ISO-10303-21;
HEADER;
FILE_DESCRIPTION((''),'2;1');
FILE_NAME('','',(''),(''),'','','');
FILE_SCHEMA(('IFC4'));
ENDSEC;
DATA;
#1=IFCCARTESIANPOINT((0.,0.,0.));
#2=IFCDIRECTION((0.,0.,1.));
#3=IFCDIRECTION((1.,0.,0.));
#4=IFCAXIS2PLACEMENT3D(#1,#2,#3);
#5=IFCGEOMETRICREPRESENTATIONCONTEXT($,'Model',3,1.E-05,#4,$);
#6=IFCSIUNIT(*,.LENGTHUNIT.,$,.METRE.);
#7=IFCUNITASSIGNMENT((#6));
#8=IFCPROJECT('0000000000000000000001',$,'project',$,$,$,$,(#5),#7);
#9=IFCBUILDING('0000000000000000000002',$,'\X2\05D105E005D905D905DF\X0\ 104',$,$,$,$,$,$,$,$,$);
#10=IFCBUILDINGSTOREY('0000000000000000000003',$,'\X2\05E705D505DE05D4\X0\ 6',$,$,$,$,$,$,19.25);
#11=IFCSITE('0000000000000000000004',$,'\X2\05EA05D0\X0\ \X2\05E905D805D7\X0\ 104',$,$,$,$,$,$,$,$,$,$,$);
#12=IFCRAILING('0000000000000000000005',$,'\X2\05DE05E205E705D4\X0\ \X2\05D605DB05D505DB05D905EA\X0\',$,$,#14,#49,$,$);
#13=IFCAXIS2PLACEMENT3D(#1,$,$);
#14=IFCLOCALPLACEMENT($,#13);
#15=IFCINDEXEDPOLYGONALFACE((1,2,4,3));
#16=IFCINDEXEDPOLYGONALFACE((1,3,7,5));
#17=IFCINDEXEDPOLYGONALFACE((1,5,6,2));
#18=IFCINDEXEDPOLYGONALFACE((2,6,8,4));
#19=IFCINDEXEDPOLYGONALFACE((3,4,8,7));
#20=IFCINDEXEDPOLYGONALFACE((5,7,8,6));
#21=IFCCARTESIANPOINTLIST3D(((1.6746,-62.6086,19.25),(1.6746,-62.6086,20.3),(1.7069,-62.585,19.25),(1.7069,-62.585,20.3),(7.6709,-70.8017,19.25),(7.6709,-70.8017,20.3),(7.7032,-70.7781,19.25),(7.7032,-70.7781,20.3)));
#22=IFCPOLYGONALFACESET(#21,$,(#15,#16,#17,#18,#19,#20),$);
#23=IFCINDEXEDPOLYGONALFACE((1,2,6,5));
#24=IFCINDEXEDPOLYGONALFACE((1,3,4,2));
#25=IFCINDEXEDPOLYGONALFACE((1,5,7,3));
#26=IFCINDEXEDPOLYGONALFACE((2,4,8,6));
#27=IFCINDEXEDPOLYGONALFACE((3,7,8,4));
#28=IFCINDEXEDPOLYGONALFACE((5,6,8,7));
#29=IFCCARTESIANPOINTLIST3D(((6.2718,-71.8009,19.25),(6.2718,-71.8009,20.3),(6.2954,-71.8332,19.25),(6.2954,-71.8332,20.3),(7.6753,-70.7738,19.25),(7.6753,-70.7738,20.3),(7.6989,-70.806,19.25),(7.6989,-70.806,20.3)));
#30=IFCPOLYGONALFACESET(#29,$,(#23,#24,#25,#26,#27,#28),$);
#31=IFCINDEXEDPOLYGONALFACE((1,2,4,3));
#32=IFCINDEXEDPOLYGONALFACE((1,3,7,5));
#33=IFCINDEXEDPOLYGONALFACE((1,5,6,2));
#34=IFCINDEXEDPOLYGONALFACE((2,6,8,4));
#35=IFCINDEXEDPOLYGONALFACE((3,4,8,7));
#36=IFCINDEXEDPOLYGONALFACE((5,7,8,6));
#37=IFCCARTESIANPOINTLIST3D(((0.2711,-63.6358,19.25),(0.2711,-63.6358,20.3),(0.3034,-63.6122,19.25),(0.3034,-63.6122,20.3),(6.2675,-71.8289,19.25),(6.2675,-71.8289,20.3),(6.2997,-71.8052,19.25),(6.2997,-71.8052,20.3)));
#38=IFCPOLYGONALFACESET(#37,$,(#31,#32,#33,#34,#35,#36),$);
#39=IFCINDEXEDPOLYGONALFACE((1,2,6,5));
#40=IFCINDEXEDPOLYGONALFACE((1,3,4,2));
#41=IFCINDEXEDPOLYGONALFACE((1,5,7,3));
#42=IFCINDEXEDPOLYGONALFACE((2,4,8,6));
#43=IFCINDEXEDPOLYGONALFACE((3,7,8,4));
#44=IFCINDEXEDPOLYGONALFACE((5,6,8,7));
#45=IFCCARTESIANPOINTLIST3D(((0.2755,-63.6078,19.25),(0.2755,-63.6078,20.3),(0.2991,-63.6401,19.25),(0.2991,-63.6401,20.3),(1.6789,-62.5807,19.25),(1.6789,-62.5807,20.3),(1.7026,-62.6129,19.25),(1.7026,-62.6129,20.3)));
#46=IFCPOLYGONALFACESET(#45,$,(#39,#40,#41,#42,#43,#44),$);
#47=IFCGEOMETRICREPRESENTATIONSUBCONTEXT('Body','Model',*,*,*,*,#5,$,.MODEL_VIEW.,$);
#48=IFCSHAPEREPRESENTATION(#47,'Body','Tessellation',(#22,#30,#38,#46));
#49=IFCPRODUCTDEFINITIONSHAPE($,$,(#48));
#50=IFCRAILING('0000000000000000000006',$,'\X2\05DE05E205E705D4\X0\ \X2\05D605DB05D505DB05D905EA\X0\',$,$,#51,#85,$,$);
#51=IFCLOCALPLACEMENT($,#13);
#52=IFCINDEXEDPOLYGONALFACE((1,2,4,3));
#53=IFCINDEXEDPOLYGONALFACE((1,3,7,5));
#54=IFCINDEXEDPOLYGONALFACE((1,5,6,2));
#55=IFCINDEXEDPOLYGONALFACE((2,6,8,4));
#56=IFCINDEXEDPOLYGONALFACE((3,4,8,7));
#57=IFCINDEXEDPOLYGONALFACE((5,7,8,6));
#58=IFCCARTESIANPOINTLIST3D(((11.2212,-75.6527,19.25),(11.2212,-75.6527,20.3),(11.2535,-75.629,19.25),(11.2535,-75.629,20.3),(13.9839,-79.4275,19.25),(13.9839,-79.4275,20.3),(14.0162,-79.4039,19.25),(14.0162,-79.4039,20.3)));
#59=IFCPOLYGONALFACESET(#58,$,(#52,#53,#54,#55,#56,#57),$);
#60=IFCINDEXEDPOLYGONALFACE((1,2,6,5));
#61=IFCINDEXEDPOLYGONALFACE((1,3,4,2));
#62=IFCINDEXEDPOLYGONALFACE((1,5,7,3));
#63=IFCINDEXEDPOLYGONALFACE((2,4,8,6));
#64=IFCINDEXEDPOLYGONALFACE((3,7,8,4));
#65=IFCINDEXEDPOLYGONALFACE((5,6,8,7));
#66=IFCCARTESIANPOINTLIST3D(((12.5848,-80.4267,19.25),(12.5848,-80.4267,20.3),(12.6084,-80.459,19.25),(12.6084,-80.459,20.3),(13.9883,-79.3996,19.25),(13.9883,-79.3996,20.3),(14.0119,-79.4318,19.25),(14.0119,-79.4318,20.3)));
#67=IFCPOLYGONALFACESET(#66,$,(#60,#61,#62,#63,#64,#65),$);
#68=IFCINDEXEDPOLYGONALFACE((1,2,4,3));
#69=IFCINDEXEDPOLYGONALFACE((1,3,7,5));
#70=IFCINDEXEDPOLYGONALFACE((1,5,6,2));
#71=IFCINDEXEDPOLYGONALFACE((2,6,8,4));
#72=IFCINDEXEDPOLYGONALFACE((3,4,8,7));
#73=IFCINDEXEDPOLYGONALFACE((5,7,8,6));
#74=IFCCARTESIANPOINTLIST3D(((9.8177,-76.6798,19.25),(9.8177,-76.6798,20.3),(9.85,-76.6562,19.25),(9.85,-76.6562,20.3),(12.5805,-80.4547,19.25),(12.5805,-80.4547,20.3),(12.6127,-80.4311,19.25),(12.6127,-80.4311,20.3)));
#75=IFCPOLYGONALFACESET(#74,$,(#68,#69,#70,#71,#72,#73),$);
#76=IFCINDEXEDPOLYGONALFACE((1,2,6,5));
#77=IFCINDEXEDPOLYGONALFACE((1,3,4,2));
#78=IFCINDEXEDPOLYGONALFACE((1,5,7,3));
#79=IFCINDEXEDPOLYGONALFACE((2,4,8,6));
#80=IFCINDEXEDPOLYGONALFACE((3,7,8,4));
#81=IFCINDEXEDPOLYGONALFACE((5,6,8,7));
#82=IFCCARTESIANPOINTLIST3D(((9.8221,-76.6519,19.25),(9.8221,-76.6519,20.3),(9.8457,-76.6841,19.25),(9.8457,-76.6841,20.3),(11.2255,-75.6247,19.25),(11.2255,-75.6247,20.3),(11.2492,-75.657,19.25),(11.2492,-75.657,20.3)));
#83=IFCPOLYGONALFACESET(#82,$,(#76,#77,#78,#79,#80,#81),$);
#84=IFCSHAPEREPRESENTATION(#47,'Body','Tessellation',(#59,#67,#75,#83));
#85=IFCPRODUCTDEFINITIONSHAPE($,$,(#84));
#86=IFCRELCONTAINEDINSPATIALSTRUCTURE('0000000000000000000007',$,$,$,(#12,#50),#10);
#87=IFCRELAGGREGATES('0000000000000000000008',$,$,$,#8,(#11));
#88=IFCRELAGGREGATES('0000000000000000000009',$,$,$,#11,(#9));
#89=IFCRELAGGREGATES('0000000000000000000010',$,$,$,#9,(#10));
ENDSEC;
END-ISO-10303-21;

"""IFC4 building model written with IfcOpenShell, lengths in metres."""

from ifc_helpers import new_model, si_unit, frame, origin_with_axes, context, subcontext, project, spatial, polyline, outline, extrude, element, save


model = new_model("IFC4")

# Units and contexts
model_context = context("Model", 3, precision=1e-05, world=origin_with_axes())
body_context = subcontext(model_context, "Body", "Model", "MODEL_VIEW")
ifc_project = project(units=[si_unit("LENGTHUNIT", "METRE")], contexts=[model_context])

# Site, building, storey
site = spatial("IfcSite", under=ifc_project, Name="תא שטח 104")
building = spatial("IfcBuilding", under=site, Name="בניין 104")
storey = spatial("IfcBuildingStorey", under=building, Name="קומה 6", Elevation=19.25)

# Railings
element("IfcRailing", 1, inside=storey, Name="מעקה זכוכית", context=body_context, shape_type="SweptSolid", body=[
    extrude(outline(polyline([(1.6746, -62.6086), (7.6709, -70.8017), (7.7032, -70.7781), (1.7069, -62.585), (1.6746, -62.6086)])), frame((0.0, 0.0, 19.25)), (0.0, 0.0, 1.0), 1.05),
    extrude(outline(polyline([(7.6753, -70.7738), (6.2718, -71.8009), (6.2954, -71.8332), (7.6989, -70.806), (7.6753, -70.7738)])), frame((0.0, 0.0, 19.25)), (0.0, 0.0, 1.0), 1.05),
    extrude(outline(polyline([(6.2997, -71.8052), (0.3034, -63.6122), (0.2711, -63.6358), (6.2675, -71.8289), (6.2997, -71.8052)])), frame((0.0, 0.0, 19.25)), (0.0, 0.0, 1.0), 1.05),
    extrude(outline(polyline([(0.2991, -63.6401), (1.7026, -62.6129), (1.6789, -62.5807), (0.2755, -63.6078), (0.2991, -63.6401)])), frame((0.0, 0.0, 19.25)), (0.0, 0.0, 1.0), 1.05),
])
element("IfcRailing", 2, inside=storey, Name="מעקה זכוכית", context=body_context, shape_type="SweptSolid", body=[
    extrude(outline(polyline([(11.2212, -75.6527), (13.9839, -79.4275), (14.0162, -79.4039), (11.2535, -75.629), (11.2212, -75.6527)])), frame((0.0, 0.0, 19.25)), (0.0, 0.0, 1.0), 1.05),
    extrude(outline(polyline([(13.9883, -79.3996), (12.5848, -80.4267), (12.6084, -80.459), (14.0119, -79.4318), (13.9883, -79.3996)])), frame((0.0, 0.0, 19.25)), (0.0, 0.0, 1.0), 1.05),
    extrude(outline(polyline([(12.6127, -80.4311), (9.85, -76.6562), (9.8177, -76.6798), (12.5805, -80.4547), (12.6127, -80.4311)])), frame((0.0, 0.0, 19.25)), (0.0, 0.0, 1.0), 1.05),
    extrude(outline(polyline([(9.8457, -76.6841), (11.2492, -75.657), (11.2255, -75.6247), (9.8221, -76.6519), (9.8457, -76.6841)])), frame((0.0, 0.0, 19.25)), (0.0, 0.0, 1.0), 1.05),
])

save(model, "model.ifc")
